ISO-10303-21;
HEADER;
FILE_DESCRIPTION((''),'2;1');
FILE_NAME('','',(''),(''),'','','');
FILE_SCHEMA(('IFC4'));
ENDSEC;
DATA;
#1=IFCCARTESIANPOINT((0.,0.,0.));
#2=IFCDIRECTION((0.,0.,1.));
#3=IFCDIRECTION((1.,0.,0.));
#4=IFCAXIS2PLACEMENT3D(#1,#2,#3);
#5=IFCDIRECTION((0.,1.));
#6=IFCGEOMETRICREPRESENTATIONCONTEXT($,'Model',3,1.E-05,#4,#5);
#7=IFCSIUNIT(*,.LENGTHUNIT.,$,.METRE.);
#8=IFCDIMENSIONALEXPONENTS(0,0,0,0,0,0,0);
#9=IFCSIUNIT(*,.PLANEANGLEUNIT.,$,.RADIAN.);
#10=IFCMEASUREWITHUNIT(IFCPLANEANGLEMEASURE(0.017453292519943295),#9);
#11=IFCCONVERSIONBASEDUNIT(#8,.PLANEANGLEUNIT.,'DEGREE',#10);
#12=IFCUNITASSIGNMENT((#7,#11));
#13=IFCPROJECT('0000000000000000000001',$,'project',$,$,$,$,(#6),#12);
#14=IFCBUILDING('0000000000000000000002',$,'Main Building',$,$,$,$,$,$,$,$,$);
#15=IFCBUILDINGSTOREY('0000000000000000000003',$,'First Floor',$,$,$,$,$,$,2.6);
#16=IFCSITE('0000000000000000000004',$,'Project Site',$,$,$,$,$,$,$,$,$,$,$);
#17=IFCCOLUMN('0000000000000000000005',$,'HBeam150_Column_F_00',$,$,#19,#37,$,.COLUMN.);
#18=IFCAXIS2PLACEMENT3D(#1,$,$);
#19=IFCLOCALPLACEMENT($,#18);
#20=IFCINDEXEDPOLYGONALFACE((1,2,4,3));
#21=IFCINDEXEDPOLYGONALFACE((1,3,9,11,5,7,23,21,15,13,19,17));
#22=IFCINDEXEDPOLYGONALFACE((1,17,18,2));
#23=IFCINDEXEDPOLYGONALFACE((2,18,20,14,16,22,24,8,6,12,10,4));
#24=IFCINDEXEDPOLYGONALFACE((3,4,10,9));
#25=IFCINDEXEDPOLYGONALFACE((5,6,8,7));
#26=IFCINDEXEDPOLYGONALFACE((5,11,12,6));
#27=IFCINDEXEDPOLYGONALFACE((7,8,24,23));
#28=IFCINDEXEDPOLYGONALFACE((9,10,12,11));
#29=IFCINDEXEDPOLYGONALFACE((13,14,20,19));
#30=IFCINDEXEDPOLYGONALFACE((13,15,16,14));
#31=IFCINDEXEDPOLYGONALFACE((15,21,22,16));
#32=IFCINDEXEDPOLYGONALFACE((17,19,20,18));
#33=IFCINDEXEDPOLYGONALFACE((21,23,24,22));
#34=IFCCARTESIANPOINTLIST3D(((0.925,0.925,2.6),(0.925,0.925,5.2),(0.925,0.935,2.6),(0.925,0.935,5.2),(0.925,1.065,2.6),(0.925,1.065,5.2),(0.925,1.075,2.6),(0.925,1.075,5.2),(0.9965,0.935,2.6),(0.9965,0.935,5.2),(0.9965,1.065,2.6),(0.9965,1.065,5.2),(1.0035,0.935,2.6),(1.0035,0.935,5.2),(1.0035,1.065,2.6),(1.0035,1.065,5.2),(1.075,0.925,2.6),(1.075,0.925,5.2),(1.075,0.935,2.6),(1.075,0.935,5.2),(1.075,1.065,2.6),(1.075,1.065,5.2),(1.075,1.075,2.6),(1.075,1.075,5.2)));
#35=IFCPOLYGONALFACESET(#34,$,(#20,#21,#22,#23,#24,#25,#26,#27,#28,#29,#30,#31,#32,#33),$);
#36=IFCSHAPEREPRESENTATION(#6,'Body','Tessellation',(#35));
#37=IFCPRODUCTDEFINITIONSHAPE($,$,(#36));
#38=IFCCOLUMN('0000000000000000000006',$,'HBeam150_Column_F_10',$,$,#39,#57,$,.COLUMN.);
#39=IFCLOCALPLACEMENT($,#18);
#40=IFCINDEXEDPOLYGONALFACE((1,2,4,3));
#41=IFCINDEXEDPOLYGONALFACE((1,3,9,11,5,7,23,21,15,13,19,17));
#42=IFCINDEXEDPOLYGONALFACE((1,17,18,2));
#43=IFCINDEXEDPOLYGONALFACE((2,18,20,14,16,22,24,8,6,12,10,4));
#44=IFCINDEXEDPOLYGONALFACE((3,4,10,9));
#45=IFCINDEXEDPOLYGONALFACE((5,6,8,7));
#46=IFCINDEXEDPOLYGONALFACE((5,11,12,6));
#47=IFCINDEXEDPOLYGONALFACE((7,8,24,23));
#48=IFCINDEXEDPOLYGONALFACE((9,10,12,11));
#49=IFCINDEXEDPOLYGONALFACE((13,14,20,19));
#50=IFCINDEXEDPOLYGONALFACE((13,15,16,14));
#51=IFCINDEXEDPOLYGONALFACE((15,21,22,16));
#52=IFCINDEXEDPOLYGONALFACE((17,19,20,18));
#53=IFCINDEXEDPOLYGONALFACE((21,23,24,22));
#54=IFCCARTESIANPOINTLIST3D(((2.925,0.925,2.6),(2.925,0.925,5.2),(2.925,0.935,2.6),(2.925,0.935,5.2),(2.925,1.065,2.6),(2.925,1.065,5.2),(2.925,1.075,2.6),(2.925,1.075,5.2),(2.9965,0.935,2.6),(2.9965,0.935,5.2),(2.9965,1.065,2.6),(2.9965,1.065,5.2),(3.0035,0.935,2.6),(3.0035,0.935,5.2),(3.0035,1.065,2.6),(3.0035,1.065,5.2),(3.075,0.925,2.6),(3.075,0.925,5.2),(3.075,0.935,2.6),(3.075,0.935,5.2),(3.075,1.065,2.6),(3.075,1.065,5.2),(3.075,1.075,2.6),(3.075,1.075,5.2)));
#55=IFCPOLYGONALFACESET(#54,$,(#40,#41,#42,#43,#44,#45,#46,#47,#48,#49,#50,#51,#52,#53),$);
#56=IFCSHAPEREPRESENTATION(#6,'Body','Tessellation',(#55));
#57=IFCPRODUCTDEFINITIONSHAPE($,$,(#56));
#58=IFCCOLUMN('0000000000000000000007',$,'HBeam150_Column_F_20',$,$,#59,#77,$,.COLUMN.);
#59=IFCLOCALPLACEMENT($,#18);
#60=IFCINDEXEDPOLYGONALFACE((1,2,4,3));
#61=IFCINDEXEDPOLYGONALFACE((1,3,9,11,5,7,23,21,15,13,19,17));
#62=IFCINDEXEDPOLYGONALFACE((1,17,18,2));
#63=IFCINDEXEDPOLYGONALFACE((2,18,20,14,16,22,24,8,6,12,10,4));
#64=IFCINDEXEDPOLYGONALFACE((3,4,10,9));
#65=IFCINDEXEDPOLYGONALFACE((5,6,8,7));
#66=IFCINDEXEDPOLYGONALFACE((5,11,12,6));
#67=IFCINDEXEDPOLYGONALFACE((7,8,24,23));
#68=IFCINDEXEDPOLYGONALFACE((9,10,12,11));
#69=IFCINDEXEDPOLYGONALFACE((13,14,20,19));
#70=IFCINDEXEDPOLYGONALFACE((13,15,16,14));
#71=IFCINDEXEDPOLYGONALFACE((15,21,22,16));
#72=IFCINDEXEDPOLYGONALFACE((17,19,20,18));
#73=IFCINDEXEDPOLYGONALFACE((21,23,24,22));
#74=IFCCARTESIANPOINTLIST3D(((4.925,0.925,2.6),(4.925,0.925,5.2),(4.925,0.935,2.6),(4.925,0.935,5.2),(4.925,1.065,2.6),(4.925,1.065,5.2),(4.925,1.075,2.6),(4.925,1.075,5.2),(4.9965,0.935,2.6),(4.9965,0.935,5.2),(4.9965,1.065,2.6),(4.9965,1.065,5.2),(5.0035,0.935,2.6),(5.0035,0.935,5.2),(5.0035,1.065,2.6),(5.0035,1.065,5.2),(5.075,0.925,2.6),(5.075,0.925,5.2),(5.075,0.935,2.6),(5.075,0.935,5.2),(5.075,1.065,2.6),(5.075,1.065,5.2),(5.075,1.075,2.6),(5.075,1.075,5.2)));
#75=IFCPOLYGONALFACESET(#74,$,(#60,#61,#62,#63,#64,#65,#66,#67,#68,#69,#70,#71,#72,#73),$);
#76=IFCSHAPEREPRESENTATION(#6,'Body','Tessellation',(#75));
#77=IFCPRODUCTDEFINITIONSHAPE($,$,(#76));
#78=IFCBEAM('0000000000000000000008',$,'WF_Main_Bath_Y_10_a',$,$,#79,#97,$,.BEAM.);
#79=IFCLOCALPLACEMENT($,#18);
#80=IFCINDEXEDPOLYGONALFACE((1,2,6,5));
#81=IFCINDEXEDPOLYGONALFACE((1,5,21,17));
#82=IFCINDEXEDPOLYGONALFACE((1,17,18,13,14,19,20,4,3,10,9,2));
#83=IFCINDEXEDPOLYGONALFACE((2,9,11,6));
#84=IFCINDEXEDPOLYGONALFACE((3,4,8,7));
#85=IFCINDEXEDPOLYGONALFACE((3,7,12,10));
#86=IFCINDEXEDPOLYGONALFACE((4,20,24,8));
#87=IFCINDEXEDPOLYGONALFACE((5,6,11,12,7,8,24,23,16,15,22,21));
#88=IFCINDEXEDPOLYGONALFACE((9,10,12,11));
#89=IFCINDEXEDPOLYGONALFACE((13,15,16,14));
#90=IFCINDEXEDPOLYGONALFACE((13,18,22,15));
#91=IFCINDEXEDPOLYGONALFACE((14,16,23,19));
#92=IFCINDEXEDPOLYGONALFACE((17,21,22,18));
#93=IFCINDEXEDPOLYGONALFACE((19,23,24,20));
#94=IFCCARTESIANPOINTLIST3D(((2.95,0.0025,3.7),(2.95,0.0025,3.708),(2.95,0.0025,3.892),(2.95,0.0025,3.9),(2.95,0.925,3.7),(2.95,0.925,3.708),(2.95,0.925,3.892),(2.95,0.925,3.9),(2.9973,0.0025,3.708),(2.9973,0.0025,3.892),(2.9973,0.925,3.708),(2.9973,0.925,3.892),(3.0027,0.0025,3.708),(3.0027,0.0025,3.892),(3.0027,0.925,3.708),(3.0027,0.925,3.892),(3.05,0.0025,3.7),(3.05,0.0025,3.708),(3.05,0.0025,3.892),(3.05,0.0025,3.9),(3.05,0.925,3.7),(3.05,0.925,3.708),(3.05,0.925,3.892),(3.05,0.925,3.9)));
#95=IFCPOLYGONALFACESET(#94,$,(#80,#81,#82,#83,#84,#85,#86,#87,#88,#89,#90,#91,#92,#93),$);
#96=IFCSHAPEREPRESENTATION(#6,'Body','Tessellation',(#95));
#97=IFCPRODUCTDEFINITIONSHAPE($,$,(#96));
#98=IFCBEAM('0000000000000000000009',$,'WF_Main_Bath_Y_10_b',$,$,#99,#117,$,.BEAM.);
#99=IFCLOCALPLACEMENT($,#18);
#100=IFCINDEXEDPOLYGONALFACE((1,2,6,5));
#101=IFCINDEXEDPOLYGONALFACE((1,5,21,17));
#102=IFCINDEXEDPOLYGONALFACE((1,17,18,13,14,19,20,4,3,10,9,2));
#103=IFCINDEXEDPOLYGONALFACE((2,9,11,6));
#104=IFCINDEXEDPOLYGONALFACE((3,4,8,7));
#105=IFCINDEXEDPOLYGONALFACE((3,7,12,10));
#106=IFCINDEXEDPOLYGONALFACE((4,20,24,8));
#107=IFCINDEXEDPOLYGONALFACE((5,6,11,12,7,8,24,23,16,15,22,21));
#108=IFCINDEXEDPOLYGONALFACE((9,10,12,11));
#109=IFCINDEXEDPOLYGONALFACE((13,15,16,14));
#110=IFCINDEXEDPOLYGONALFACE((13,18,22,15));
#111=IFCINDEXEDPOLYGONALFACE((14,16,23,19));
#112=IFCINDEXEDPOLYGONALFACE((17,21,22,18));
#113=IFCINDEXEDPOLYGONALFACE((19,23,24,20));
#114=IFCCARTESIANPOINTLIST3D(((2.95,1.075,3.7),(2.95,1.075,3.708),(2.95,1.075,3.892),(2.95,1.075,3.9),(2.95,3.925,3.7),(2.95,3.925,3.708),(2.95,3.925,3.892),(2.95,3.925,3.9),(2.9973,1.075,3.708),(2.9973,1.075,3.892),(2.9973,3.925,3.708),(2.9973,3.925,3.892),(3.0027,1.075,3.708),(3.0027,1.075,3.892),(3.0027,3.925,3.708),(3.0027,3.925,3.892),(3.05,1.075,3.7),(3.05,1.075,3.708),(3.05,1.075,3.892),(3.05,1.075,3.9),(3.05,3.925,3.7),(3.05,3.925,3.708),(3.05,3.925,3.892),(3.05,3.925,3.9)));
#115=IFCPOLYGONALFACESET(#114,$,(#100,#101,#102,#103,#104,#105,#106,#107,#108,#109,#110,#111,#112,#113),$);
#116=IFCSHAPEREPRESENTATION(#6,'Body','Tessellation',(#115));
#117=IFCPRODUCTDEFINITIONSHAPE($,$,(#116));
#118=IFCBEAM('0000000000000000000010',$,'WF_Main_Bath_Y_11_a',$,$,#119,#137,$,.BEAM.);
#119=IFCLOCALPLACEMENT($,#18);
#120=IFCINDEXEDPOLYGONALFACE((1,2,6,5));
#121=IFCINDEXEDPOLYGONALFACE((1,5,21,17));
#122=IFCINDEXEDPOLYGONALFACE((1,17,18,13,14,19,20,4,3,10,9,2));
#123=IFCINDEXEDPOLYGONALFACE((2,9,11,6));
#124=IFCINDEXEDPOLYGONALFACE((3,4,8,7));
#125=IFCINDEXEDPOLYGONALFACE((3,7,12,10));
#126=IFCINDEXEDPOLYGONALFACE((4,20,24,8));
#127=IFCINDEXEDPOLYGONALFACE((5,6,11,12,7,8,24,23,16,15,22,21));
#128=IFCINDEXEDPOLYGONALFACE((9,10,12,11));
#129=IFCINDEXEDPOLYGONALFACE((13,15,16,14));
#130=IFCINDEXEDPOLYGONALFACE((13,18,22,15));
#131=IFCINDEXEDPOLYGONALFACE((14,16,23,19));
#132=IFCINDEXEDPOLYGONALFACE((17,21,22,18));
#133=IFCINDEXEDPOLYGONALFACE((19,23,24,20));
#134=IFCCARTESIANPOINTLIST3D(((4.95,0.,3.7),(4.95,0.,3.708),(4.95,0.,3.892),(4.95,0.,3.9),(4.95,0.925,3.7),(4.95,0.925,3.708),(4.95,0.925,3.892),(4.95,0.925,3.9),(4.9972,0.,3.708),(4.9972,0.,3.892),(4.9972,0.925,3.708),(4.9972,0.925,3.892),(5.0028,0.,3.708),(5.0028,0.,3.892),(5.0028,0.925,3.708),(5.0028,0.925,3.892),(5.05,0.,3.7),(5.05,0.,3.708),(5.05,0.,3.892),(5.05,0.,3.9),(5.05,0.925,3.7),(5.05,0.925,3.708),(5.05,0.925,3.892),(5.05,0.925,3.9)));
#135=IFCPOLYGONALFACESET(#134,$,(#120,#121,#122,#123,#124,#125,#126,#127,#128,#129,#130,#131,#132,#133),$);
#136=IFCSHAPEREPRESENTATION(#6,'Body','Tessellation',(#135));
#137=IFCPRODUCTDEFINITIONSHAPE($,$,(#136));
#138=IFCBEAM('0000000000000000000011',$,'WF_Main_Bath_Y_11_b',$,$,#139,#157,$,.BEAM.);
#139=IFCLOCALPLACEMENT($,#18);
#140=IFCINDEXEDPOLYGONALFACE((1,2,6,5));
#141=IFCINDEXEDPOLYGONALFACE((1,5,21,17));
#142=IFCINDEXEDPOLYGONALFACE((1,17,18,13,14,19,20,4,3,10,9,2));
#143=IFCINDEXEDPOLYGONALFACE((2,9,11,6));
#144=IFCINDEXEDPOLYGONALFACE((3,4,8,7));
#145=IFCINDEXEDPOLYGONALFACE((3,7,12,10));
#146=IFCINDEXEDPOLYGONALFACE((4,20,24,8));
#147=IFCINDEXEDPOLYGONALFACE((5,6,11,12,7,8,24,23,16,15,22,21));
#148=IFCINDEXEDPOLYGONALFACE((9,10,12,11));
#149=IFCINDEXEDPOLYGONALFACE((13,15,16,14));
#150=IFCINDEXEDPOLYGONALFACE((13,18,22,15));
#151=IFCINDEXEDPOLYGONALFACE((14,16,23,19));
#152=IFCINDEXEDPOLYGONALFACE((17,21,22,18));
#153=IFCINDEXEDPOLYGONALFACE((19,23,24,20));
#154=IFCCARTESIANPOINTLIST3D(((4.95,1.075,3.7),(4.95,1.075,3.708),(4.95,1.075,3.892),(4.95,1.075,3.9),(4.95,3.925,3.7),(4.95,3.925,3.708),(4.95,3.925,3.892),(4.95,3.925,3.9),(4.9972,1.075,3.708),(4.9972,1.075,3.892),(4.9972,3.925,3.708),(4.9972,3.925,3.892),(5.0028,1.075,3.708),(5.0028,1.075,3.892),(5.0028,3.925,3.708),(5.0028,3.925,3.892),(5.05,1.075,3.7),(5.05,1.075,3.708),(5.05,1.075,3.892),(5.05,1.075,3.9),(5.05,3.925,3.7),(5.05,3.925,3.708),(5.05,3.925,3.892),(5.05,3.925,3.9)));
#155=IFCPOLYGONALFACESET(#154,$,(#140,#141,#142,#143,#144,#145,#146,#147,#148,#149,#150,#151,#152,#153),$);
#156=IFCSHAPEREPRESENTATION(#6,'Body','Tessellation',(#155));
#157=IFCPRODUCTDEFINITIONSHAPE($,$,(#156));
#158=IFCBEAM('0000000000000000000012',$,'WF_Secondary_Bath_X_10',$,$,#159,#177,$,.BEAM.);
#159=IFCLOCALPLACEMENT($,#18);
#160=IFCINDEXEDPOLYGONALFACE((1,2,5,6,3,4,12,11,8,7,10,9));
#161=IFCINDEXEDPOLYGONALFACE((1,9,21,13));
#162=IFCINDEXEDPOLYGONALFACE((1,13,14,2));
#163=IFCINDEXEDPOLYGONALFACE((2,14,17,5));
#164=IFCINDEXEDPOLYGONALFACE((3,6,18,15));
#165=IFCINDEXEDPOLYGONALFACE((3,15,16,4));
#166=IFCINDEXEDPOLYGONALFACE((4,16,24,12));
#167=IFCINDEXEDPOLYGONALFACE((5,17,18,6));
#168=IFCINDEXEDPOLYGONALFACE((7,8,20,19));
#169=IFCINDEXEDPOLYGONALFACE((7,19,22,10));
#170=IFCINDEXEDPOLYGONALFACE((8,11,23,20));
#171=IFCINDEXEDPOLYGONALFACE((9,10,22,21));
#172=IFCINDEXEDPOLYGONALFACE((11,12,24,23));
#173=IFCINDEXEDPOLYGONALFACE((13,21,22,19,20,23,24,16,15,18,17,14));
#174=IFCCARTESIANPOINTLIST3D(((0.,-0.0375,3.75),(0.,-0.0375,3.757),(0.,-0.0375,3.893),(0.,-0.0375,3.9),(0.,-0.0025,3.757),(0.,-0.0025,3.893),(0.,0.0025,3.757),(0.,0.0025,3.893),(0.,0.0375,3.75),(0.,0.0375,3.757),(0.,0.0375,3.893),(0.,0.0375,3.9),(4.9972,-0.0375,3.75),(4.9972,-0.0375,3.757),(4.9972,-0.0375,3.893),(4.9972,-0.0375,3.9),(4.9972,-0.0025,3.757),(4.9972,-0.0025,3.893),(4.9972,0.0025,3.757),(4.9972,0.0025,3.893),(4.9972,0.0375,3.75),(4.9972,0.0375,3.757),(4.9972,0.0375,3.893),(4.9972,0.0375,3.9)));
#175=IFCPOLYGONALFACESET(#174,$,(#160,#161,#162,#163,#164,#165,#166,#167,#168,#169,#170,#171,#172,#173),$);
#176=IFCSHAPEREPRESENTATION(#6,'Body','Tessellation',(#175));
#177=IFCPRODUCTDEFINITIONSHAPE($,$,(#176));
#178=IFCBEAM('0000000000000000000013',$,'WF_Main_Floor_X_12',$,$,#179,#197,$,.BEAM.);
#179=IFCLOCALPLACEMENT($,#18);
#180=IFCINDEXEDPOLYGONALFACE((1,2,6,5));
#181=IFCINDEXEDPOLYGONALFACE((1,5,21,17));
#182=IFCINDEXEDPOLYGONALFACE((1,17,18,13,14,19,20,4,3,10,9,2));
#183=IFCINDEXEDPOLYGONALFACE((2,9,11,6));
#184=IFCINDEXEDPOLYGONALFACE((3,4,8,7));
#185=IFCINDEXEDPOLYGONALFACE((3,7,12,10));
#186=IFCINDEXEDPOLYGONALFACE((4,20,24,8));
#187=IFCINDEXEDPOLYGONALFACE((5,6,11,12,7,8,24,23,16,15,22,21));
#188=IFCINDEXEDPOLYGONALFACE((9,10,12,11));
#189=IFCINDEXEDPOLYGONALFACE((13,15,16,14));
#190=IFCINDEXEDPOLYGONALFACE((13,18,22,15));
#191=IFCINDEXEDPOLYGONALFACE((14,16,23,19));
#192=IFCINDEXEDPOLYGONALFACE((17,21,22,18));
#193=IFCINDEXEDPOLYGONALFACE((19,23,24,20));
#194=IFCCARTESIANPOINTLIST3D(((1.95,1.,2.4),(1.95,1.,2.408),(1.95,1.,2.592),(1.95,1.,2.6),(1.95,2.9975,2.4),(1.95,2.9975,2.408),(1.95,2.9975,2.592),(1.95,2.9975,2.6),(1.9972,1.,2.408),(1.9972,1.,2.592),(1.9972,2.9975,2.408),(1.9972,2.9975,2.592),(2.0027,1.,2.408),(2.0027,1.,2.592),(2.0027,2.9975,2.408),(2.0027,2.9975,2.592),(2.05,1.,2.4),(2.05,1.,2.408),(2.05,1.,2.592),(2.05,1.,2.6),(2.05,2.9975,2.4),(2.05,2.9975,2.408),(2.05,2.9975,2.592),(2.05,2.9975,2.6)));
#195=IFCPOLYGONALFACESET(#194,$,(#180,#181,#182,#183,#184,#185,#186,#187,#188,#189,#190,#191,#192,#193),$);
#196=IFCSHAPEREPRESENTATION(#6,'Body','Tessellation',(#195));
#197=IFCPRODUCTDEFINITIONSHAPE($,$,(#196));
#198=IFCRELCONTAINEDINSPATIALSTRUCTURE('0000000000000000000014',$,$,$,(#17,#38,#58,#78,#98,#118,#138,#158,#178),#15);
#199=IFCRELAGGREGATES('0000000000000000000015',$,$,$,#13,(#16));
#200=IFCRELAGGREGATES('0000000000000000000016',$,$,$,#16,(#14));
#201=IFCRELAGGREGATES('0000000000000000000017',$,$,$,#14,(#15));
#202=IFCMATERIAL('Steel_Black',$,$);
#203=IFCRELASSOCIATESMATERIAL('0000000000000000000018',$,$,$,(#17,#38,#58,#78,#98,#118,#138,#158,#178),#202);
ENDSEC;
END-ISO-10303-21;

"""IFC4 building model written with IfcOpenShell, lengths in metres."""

from ifc_helpers import new_model, entity, si_unit, converted_unit, direction, frame, frame_2d, origin, origin_with_axes, origin_2d, place, context, project, spatial, i_section, extrude, material, element, save


model = new_model("IFC4")

# Units and contexts
model_context = context("Model", 3, precision=1e-05, world=origin_with_axes(), true_north=direction((0.0, 1.0)))
ifc_project = project(units=[si_unit("LENGTHUNIT", "METRE"), converted_unit("PLANEANGLEUNIT", "DEGREE", entity("IfcPlaneAngleMeasure", 0.017453292519943295), si_unit("PLANEANGLEUNIT", "RADIAN"), dimensions=[0, 0, 0, 0, 0, 0, 0])], contexts=[model_context])

# Site, building, storey
site = spatial("IfcSite", under=ifc_project, Name="Project Site")
building = spatial("IfcBuilding", under=site, Name="Main Building")
storey = spatial("IfcBuildingStorey", under=building, Name="First Floor", Elevation=2.6)

# Columns
ifc_material = material(Name="Steel_Black")
for number, where, z_axis, x_axis, name in (
    (1, (1.0, 1.0, 2.6), (0.0, 0.0, 1.0), (1.0, 0.0, 0.0), "HBeam150_Column_F_00"),
    (2, (3.0, 1.0, 2.6), (0.0, 0.0, 1.0), (1.0, 0.0, 0.0), "HBeam150_Column_F_10"),
    (3, (5.0, 1.0, 2.6), (0.0, 0.0, 1.0), (1.0, 0.0, 0.0), "HBeam150_Column_F_20"),
):
    element("IfcColumn", number, at=place(None, frame(where, z_axis=z_axis, x_axis=x_axis)), inside=storey, material=ifc_material, Name=name, PredefinedType="COLUMN", context=model_context, shape_type="SweptSolid", body=[
        extrude(i_section(OverallWidth=0.15, OverallDepth=0.15, WebThickness=0.007, FlangeThickness=0.01, at=origin_2d()), origin(), (0.0, 0.0, 1.0), 2.6),
    ])

# Beams
beam_1_placement = place(None, frame((3.0, 0.0025, 3.7), z_axis=(0.0, 0.0, 1.0), x_axis=(0.0, 1.0, 0.0)))
element("IfcBeam", 4, at=beam_1_placement, inside=storey, material=ifc_material, Name="WF_Main_Bath_Y_10_a", PredefinedType="BEAM", context=model_context, shape_type="SweptSolid", body=[
    extrude(i_section(OverallWidth=0.1, OverallDepth=0.2, WebThickness=0.0055, FlangeThickness=0.008, at=frame_2d((0.0, 0.1))), frame((0.0, 0.0, 0.0), z_axis=(1.0, 0.0, 0.0), x_axis=(0.0, 1.0, 0.0)), (0.0, 0.0, 1.0), 0.9225),
])
beam_2_placement = place(None, frame((3.0, 1.075, 3.7), z_axis=(0.0, 0.0, 1.0), x_axis=(0.0, 1.0, 0.0)))
element("IfcBeam", 5, at=beam_2_placement, inside=storey, material=ifc_material, Name="WF_Main_Bath_Y_10_b", PredefinedType="BEAM", context=model_context, shape_type="SweptSolid", body=[
    extrude(i_section(OverallWidth=0.1, OverallDepth=0.2, WebThickness=0.0055, FlangeThickness=0.008, at=frame_2d((0.0, 0.1))), frame((0.0, 0.0, 0.0), z_axis=(1.0, 0.0, 0.0), x_axis=(0.0, 1.0, 0.0)), (0.0, 0.0, 1.0), 2.85),
])
beam_3_placement = place(None, frame((5.0, 0.0, 3.7), z_axis=(0.0, 0.0, 1.0), x_axis=(0.0, 1.0, 0.0)))
element("IfcBeam", 6, at=beam_3_placement, inside=storey, material=ifc_material, Name="WF_Main_Bath_Y_11_a", PredefinedType="BEAM", context=model_context, shape_type="SweptSolid", body=[
    extrude(i_section(OverallWidth=0.1, OverallDepth=0.2, WebThickness=0.0055, FlangeThickness=0.008, at=frame_2d((0.0, 0.1))), frame((0.0, 0.0, 0.0), z_axis=(1.0, 0.0, 0.0), x_axis=(0.0, 1.0, 0.0)), (0.0, 0.0, 1.0), 0.925),
])
beam_4_placement = place(None, frame((5.0, 1.075, 3.7), z_axis=(0.0, 0.0, 1.0), x_axis=(0.0, 1.0, 0.0)))
element("IfcBeam", 7, at=beam_4_placement, inside=storey, material=ifc_material, Name="WF_Main_Bath_Y_11_b", PredefinedType="BEAM", context=model_context, shape_type="SweptSolid", body=[
    extrude(i_section(OverallWidth=0.1, OverallDepth=0.2, WebThickness=0.0055, FlangeThickness=0.008, at=frame_2d((0.0, 0.1))), frame((0.0, 0.0, 0.0), z_axis=(1.0, 0.0, 0.0), x_axis=(0.0, 1.0, 0.0)), (0.0, 0.0, 1.0), 2.85),
])
beam_5_placement = place(None, frame((0.0, 0.0, 3.75), z_axis=(0.0, 0.0, 1.0), x_axis=(1.0, 0.0, 0.0)))
element("IfcBeam", 8, at=beam_5_placement, inside=storey, material=ifc_material, Name="WF_Secondary_Bath_X_10", PredefinedType="BEAM", context=model_context, shape_type="SweptSolid", body=[
    extrude(i_section(OverallWidth=0.075, OverallDepth=0.15, WebThickness=0.005, FlangeThickness=0.007, at=frame_2d((0.0, 0.075))), frame((0.0, 0.0, 0.0), z_axis=(1.0, 0.0, 0.0), x_axis=(0.0, 1.0, 0.0)), (0.0, 0.0, 1.0), 4.9973),
])
beam_6_placement = place(None, frame((2.0, 1.0, 2.4), z_axis=(0.0, 0.0, 1.0), x_axis=(0.0, 1.0, 0.0)))
element("IfcBeam", 9, at=beam_6_placement, inside=storey, material=ifc_material, Name="WF_Main_Floor_X_12", PredefinedType="BEAM", context=model_context, shape_type="SweptSolid", body=[
    extrude(i_section(OverallWidth=0.1, OverallDepth=0.2, WebThickness=0.0055, FlangeThickness=0.008, at=frame_2d((0.0, 0.1))), frame((0.0, 0.0, 0.0), z_axis=(1.0, 0.0, 0.0), x_axis=(0.0, 1.0, 0.0)), (0.0, 0.0, 1.0), 1.9975),
])

save(model, "model.ifc")
